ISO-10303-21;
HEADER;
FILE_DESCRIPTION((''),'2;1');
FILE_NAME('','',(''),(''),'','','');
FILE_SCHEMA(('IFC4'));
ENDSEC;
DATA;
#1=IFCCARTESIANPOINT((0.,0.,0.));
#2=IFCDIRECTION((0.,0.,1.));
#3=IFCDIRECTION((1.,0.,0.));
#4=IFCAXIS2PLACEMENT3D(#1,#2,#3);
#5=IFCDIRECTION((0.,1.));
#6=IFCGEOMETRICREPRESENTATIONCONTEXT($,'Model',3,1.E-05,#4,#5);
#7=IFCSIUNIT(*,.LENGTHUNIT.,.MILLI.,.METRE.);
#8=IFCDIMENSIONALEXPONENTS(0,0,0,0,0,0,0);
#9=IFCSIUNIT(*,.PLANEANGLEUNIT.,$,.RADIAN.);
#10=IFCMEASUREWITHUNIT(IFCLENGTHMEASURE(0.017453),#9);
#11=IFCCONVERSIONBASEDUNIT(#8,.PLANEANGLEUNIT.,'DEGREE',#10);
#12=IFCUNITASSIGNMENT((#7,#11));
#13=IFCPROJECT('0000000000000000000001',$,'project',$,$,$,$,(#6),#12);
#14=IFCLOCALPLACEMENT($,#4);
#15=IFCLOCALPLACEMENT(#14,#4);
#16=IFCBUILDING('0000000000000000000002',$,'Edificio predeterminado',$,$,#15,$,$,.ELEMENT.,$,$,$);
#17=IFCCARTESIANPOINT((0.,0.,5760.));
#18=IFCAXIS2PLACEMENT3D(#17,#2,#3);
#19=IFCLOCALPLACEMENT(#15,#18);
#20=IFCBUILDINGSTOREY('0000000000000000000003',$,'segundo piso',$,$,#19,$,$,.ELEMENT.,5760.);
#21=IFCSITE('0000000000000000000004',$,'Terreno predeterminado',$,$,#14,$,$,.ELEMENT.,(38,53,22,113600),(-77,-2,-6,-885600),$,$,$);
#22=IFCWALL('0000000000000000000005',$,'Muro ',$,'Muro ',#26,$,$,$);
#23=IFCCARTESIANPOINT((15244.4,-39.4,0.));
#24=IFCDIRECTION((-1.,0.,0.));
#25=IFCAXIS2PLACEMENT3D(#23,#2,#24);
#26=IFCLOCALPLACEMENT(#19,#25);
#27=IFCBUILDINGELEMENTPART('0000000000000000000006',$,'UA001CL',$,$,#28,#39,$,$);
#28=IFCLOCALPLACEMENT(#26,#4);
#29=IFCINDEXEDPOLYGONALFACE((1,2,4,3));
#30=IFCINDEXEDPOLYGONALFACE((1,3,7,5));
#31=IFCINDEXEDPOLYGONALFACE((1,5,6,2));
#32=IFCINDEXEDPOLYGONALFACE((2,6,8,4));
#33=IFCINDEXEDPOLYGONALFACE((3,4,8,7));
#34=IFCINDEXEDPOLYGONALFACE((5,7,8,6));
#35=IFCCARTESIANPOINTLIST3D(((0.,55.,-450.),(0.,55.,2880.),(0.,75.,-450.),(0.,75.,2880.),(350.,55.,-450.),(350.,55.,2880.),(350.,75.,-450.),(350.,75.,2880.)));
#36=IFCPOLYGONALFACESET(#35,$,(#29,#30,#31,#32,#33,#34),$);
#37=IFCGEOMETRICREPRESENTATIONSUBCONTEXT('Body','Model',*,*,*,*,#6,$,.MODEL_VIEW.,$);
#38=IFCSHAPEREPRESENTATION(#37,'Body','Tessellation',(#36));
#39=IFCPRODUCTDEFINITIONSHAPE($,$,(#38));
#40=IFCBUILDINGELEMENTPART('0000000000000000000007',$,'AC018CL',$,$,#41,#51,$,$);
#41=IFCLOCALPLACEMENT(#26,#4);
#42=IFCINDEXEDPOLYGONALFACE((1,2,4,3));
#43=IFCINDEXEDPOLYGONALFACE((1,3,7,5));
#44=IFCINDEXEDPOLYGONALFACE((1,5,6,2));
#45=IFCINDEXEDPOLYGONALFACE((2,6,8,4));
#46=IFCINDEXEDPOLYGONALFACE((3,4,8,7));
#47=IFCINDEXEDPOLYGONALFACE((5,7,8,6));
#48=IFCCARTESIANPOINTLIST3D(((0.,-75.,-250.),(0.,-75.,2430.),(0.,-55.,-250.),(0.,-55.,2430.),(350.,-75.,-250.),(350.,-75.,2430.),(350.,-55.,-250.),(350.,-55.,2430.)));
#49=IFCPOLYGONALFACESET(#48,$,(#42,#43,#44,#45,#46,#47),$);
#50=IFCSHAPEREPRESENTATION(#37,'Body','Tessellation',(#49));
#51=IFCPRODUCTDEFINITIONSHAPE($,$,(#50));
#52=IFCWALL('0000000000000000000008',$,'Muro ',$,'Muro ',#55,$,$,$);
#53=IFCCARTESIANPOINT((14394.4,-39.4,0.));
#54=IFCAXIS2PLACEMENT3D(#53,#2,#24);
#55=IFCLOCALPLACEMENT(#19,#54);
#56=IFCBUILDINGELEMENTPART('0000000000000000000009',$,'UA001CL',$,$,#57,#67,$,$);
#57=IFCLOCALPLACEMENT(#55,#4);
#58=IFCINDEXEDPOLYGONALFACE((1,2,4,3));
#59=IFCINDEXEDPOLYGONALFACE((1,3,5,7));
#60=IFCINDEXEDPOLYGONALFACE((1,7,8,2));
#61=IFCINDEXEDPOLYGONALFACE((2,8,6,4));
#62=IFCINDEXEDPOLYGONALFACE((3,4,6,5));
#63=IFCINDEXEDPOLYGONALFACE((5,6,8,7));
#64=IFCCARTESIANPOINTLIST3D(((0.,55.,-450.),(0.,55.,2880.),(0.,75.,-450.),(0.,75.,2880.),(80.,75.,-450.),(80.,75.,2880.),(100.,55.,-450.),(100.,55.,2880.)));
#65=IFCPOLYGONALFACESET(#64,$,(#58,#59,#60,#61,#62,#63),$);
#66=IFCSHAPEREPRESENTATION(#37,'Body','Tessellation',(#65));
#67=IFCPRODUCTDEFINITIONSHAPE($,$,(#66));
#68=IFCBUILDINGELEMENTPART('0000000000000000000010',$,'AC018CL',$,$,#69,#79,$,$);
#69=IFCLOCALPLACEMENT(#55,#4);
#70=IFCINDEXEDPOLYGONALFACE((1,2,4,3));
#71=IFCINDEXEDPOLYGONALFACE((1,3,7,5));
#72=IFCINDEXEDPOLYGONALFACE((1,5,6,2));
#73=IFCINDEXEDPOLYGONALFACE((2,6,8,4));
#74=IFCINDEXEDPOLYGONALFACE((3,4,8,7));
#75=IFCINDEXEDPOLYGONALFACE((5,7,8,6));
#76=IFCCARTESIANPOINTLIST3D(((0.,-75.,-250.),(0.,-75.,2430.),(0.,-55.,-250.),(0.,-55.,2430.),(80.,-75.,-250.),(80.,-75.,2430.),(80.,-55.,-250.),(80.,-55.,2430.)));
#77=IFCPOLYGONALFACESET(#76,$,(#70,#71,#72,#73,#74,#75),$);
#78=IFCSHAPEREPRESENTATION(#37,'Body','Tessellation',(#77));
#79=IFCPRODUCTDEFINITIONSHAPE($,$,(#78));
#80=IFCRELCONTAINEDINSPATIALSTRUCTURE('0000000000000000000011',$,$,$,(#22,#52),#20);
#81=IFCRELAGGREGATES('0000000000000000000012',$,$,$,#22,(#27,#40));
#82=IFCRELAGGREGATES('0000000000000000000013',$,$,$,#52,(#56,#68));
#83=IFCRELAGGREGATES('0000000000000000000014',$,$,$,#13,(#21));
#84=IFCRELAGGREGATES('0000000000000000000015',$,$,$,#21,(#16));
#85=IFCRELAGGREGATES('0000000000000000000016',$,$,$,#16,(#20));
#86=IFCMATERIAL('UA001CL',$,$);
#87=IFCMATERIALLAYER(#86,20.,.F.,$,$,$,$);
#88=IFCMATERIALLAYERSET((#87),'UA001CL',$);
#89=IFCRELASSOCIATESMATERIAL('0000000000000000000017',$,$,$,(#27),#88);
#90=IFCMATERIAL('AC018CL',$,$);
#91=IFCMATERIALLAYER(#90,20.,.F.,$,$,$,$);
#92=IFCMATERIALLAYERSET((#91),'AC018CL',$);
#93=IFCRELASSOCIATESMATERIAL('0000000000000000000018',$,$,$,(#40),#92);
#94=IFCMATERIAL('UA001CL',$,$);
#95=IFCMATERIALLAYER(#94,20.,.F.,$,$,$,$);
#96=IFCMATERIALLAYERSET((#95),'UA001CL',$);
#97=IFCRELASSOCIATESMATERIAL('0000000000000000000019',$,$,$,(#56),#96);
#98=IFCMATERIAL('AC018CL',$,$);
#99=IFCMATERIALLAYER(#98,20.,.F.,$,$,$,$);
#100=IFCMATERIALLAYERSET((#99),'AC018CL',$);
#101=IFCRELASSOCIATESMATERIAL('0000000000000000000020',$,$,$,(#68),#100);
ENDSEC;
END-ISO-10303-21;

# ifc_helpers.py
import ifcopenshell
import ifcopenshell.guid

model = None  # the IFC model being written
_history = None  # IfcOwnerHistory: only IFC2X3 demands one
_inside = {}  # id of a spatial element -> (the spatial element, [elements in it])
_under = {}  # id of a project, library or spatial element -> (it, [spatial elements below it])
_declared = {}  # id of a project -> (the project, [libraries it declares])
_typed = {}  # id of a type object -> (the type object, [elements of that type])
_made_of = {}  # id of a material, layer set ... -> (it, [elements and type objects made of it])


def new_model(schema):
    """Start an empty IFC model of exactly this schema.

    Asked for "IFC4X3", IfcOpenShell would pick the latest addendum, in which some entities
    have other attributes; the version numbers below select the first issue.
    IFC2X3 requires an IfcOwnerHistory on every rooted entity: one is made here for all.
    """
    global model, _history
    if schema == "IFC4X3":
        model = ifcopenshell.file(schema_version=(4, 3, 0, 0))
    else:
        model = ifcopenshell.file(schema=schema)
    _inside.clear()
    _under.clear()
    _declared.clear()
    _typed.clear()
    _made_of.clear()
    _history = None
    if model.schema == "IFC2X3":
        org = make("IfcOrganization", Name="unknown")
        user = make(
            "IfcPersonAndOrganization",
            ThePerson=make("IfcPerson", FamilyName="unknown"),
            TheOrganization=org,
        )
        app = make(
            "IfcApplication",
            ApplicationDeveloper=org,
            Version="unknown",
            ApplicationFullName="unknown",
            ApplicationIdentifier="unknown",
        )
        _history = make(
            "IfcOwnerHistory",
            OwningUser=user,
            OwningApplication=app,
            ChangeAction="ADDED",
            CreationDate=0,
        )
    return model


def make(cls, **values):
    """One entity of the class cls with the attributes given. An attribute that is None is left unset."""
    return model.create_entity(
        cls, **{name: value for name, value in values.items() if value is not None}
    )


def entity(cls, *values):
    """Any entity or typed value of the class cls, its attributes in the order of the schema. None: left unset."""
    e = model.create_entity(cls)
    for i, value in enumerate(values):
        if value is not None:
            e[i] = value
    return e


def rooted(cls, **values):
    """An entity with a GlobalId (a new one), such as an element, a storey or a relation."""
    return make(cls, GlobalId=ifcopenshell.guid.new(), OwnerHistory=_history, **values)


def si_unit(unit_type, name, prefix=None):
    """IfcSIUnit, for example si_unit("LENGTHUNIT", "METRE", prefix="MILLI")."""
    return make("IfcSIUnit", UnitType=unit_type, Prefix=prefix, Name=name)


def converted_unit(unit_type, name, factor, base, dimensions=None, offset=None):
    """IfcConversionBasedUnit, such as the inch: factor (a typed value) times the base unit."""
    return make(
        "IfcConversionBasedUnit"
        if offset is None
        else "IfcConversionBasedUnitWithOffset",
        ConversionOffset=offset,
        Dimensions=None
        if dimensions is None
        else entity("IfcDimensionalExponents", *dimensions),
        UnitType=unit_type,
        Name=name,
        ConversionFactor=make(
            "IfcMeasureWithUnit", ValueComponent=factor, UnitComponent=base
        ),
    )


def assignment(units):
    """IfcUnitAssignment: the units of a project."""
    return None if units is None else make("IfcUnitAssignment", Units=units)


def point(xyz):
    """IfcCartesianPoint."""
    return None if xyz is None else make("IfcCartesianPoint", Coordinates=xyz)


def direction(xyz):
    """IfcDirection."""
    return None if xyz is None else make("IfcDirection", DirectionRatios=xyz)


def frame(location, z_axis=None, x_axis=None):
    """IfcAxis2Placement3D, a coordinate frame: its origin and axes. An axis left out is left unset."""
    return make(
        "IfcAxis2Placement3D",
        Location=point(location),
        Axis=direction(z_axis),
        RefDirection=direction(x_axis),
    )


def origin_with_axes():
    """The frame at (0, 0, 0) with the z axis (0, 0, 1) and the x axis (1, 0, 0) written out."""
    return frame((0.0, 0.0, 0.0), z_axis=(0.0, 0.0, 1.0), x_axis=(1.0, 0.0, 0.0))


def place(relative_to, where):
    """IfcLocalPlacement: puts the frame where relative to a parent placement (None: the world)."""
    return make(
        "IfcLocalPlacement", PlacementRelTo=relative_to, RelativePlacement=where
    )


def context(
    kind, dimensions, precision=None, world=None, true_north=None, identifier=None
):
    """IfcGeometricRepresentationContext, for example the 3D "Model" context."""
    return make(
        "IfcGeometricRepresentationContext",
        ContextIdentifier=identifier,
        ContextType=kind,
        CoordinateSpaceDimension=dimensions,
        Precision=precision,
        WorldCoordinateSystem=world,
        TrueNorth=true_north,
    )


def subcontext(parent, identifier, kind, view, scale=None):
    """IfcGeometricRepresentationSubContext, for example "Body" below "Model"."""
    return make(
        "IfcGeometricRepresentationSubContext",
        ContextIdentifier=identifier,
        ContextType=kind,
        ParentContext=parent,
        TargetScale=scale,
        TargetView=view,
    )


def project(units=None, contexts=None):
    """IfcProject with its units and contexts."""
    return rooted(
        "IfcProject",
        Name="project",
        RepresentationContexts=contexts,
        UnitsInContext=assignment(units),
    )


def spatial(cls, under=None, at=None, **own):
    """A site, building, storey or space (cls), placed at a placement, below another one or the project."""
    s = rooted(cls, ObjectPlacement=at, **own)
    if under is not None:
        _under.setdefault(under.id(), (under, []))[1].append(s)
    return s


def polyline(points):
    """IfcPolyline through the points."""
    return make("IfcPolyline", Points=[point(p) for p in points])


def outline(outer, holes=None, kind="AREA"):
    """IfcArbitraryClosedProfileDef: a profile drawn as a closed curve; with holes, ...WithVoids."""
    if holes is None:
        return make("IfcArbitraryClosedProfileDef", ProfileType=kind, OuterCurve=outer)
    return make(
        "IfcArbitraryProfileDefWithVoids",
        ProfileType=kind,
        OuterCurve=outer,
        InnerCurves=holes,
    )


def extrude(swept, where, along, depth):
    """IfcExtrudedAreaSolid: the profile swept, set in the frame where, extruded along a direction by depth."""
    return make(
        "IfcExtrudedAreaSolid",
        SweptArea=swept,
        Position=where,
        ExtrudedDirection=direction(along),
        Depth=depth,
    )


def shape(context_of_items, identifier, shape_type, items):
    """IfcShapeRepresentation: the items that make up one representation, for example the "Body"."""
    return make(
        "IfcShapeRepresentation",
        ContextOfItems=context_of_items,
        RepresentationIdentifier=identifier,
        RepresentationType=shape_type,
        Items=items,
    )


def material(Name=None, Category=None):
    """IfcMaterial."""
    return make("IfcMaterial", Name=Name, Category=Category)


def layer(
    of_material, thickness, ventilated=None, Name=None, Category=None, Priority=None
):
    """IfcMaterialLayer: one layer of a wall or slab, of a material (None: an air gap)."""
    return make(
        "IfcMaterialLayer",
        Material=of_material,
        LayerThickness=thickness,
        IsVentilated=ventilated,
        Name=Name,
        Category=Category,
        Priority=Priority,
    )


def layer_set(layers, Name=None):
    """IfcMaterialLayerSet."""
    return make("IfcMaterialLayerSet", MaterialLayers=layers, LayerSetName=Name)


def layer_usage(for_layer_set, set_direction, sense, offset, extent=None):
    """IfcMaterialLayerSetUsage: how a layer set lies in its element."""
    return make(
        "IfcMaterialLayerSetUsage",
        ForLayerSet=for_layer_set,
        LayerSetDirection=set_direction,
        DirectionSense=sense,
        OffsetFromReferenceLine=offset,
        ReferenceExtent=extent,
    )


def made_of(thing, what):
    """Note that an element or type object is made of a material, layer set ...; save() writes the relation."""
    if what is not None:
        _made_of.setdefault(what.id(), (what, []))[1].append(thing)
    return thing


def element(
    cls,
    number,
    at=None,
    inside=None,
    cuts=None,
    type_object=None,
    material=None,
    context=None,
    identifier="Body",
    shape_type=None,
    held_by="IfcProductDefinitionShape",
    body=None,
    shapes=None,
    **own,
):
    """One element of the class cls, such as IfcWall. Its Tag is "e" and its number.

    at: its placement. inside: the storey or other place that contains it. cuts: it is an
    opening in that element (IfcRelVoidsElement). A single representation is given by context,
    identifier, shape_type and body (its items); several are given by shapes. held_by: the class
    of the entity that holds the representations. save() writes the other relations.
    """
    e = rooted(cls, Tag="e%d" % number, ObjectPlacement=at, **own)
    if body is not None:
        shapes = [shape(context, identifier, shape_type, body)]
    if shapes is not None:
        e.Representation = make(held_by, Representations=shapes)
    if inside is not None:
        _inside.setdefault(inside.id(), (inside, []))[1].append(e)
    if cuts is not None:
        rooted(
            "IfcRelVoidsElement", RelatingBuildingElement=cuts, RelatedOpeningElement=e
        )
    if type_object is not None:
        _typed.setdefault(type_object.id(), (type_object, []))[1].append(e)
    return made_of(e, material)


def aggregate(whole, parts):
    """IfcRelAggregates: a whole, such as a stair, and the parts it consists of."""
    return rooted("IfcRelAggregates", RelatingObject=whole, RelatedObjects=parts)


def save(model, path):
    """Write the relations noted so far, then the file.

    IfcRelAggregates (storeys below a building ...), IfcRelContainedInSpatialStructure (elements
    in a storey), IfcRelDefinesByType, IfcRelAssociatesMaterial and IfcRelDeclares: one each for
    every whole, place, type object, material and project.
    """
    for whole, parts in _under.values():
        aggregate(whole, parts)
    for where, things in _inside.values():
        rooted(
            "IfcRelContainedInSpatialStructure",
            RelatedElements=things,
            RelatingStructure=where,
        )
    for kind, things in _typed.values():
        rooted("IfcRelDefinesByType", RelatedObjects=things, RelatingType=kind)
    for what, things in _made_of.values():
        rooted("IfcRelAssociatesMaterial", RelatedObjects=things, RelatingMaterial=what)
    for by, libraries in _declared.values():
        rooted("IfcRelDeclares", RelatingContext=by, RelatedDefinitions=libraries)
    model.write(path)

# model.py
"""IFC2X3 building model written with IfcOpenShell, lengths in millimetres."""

from ifc_helpers import new_model, entity, si_unit, converted_unit, direction, frame, origin_with_axes, place, context, subcontext, project, spatial, polyline, outline, extrude, material, layer, layer_set, layer_usage, element, aggregate, save


model = new_model("IFC2X3")

# Units and contexts
model_context = context("Model", 3, precision=1e-05, world=origin_with_axes(), true_north=direction((0.0, 1.0)))
body_context = subcontext(model_context, "Body", "Model", "MODEL_VIEW")
ifc_project = project(units=[si_unit("LENGTHUNIT", "METRE", prefix="MILLI"), converted_unit("PLANEANGLEUNIT", "DEGREE", entity("IfcLengthMeasure", 0.017453), si_unit("PLANEANGLEUNIT", "RADIAN"), dimensions=[0, 0, 0, 0, 0, 0, 0])], contexts=[model_context])

# Site, building, storey
site_placement = place(None, origin_with_axes())
site = spatial("IfcSite", under=ifc_project, at=site_placement, Name="Terreno predeterminado", CompositionType="ELEMENT", RefLatitude=(38, 53, 22, 113600), RefLongitude=(-77, -2, -6, -885600))
building_placement = place(site_placement, origin_with_axes())
building = spatial("IfcBuilding", under=site, at=building_placement, Name="Edificio predeterminado", CompositionType="ELEMENT")
storey_placement = place(building_placement, frame((0.0, 0.0, 5760.0), z_axis=(0.0, 0.0, 1.0), x_axis=(1.0, 0.0, 0.0)))
storey = spatial("IfcBuildingStorey", under=building, at=storey_placement, Name="segundo piso", CompositionType="ELEMENT", Elevation=5760.0)

# Walls, building element parts
wall_1_placement = place(storey_placement, frame((15244.4, -39.4, 0.0), z_axis=(0.0, 0.0, 1.0), x_axis=(-1.0, 0.0, 0.0)))
wall_1 = element("IfcWall", 1, at=wall_1_placement, inside=storey, Name="Muro ", ObjectType="Muro ")
ifc_material_1 = material(Name="UA001CL")
ifc_layer_1 = layer(ifc_material_1, 20.0, ventilated=False)
ifc_layer_set_1 = layer_set([ifc_layer_1], Name="UA001CL")
ifc_layer_usage_1 = layer_usage(ifc_layer_set_1, "AXIS2", "NEGATIVE", -75.0)
building_element_part_1_placement = place(wall_1_placement, origin_with_axes())
building_element_part_1 = element("IfcBuildingElementPart", 2, at=building_element_part_1_placement, material=ifc_layer_usage_1, Name="UA001CL", context=body_context, shape_type="SweptSolid", body=[
    extrude(outline(polyline([(350.0, 75.0), (350.0, 55.0), (0.0, 55.0), (0.0, 75.0), (350.0, 75.0)])), frame((0.0, 0.0, -450.0), z_axis=(0.0, 0.0, 1.0), x_axis=(1.0, 0.0, 0.0)), (0.0, 0.0, 1.0), 3330.0),
])
ifc_material_2 = material(Name="AC018CL")
ifc_layer_2 = layer(ifc_material_2, 20.0, ventilated=False)
ifc_layer_set_2 = layer_set([ifc_layer_2], Name="AC018CL")
ifc_layer_usage_2 = layer_usage(ifc_layer_set_2, "AXIS2", "NEGATIVE", 55.0)
building_element_part_2_placement = place(wall_1_placement, origin_with_axes())
building_element_part_2 = element("IfcBuildingElementPart", 3, at=building_element_part_2_placement, material=ifc_layer_usage_2, Name="AC018CL", context=body_context, shape_type="SweptSolid", body=[
    extrude(outline(polyline([(350.0, -55.0), (350.0, -75.0), (0.0, -75.0), (0.0, -55.0), (350.0, -55.0)])), frame((0.0, 0.0, -250.0), z_axis=(0.0, 0.0, 1.0), x_axis=(1.0, 0.0, 0.0)), (0.0, 0.0, 1.0), 2680.0),
])
aggregate(wall_1, [building_element_part_1, building_element_part_2])
wall_2_placement = place(storey_placement, frame((14394.4, -39.4, 0.0), z_axis=(0.0, 0.0, 1.0), x_axis=(-1.0, 0.0, 0.0)))
wall_2 = element("IfcWall", 4, at=wall_2_placement, inside=storey, Name="Muro ", ObjectType="Muro ")
ifc_material_3 = material(Name="UA001CL")
ifc_layer_3 = layer(ifc_material_3, 20.0, ventilated=False)
ifc_layer_set_3 = layer_set([ifc_layer_3], Name="UA001CL")
ifc_layer_usage_3 = layer_usage(ifc_layer_set_3, "AXIS2", "NEGATIVE", -75.0)
building_element_part_3_placement = place(wall_2_placement, origin_with_axes())
building_element_part_3 = element("IfcBuildingElementPart", 5, at=building_element_part_3_placement, material=ifc_layer_usage_3, Name="UA001CL", context=body_context, shape_type="SweptSolid", body=[
    extrude(outline(polyline([(80.0, 75.0), (100.0, 55.0), (0.0, 55.0), (0.0, 75.0), (80.0, 75.0)])), frame((0.0, 0.0, -450.0), z_axis=(0.0, 0.0, 1.0), x_axis=(1.0, 0.0, 0.0)), (0.0, 0.0, 1.0), 3330.0),
])
ifc_material_4 = material(Name="AC018CL")
ifc_layer_4 = layer(ifc_material_4, 20.0, ventilated=False)
ifc_layer_set_4 = layer_set([ifc_layer_4], Name="AC018CL")
ifc_layer_usage_4 = layer_usage(ifc_layer_set_4, "AXIS2", "NEGATIVE", 55.0)
building_element_part_4_placement = place(wall_2_placement, origin_with_axes())
building_element_part_4 = element("IfcBuildingElementPart", 6, at=building_element_part_4_placement, material=ifc_layer_usage_4, Name="AC018CL", context=body_context, shape_type="SweptSolid", body=[
    extrude(outline(polyline([(80.0, -55.0), (80.0, -75.0), (0.0, -75.0), (0.0, -55.0), (80.0, -55.0)])), frame((0.0, 0.0, -250.0), z_axis=(0.0, 0.0, 1.0), x_axis=(1.0, 0.0, 0.0)), (0.0, 0.0, 1.0), 2680.0),
])
aggregate(wall_2, [building_element_part_3, building_element_part_4])

save(model, "model.ifc")
